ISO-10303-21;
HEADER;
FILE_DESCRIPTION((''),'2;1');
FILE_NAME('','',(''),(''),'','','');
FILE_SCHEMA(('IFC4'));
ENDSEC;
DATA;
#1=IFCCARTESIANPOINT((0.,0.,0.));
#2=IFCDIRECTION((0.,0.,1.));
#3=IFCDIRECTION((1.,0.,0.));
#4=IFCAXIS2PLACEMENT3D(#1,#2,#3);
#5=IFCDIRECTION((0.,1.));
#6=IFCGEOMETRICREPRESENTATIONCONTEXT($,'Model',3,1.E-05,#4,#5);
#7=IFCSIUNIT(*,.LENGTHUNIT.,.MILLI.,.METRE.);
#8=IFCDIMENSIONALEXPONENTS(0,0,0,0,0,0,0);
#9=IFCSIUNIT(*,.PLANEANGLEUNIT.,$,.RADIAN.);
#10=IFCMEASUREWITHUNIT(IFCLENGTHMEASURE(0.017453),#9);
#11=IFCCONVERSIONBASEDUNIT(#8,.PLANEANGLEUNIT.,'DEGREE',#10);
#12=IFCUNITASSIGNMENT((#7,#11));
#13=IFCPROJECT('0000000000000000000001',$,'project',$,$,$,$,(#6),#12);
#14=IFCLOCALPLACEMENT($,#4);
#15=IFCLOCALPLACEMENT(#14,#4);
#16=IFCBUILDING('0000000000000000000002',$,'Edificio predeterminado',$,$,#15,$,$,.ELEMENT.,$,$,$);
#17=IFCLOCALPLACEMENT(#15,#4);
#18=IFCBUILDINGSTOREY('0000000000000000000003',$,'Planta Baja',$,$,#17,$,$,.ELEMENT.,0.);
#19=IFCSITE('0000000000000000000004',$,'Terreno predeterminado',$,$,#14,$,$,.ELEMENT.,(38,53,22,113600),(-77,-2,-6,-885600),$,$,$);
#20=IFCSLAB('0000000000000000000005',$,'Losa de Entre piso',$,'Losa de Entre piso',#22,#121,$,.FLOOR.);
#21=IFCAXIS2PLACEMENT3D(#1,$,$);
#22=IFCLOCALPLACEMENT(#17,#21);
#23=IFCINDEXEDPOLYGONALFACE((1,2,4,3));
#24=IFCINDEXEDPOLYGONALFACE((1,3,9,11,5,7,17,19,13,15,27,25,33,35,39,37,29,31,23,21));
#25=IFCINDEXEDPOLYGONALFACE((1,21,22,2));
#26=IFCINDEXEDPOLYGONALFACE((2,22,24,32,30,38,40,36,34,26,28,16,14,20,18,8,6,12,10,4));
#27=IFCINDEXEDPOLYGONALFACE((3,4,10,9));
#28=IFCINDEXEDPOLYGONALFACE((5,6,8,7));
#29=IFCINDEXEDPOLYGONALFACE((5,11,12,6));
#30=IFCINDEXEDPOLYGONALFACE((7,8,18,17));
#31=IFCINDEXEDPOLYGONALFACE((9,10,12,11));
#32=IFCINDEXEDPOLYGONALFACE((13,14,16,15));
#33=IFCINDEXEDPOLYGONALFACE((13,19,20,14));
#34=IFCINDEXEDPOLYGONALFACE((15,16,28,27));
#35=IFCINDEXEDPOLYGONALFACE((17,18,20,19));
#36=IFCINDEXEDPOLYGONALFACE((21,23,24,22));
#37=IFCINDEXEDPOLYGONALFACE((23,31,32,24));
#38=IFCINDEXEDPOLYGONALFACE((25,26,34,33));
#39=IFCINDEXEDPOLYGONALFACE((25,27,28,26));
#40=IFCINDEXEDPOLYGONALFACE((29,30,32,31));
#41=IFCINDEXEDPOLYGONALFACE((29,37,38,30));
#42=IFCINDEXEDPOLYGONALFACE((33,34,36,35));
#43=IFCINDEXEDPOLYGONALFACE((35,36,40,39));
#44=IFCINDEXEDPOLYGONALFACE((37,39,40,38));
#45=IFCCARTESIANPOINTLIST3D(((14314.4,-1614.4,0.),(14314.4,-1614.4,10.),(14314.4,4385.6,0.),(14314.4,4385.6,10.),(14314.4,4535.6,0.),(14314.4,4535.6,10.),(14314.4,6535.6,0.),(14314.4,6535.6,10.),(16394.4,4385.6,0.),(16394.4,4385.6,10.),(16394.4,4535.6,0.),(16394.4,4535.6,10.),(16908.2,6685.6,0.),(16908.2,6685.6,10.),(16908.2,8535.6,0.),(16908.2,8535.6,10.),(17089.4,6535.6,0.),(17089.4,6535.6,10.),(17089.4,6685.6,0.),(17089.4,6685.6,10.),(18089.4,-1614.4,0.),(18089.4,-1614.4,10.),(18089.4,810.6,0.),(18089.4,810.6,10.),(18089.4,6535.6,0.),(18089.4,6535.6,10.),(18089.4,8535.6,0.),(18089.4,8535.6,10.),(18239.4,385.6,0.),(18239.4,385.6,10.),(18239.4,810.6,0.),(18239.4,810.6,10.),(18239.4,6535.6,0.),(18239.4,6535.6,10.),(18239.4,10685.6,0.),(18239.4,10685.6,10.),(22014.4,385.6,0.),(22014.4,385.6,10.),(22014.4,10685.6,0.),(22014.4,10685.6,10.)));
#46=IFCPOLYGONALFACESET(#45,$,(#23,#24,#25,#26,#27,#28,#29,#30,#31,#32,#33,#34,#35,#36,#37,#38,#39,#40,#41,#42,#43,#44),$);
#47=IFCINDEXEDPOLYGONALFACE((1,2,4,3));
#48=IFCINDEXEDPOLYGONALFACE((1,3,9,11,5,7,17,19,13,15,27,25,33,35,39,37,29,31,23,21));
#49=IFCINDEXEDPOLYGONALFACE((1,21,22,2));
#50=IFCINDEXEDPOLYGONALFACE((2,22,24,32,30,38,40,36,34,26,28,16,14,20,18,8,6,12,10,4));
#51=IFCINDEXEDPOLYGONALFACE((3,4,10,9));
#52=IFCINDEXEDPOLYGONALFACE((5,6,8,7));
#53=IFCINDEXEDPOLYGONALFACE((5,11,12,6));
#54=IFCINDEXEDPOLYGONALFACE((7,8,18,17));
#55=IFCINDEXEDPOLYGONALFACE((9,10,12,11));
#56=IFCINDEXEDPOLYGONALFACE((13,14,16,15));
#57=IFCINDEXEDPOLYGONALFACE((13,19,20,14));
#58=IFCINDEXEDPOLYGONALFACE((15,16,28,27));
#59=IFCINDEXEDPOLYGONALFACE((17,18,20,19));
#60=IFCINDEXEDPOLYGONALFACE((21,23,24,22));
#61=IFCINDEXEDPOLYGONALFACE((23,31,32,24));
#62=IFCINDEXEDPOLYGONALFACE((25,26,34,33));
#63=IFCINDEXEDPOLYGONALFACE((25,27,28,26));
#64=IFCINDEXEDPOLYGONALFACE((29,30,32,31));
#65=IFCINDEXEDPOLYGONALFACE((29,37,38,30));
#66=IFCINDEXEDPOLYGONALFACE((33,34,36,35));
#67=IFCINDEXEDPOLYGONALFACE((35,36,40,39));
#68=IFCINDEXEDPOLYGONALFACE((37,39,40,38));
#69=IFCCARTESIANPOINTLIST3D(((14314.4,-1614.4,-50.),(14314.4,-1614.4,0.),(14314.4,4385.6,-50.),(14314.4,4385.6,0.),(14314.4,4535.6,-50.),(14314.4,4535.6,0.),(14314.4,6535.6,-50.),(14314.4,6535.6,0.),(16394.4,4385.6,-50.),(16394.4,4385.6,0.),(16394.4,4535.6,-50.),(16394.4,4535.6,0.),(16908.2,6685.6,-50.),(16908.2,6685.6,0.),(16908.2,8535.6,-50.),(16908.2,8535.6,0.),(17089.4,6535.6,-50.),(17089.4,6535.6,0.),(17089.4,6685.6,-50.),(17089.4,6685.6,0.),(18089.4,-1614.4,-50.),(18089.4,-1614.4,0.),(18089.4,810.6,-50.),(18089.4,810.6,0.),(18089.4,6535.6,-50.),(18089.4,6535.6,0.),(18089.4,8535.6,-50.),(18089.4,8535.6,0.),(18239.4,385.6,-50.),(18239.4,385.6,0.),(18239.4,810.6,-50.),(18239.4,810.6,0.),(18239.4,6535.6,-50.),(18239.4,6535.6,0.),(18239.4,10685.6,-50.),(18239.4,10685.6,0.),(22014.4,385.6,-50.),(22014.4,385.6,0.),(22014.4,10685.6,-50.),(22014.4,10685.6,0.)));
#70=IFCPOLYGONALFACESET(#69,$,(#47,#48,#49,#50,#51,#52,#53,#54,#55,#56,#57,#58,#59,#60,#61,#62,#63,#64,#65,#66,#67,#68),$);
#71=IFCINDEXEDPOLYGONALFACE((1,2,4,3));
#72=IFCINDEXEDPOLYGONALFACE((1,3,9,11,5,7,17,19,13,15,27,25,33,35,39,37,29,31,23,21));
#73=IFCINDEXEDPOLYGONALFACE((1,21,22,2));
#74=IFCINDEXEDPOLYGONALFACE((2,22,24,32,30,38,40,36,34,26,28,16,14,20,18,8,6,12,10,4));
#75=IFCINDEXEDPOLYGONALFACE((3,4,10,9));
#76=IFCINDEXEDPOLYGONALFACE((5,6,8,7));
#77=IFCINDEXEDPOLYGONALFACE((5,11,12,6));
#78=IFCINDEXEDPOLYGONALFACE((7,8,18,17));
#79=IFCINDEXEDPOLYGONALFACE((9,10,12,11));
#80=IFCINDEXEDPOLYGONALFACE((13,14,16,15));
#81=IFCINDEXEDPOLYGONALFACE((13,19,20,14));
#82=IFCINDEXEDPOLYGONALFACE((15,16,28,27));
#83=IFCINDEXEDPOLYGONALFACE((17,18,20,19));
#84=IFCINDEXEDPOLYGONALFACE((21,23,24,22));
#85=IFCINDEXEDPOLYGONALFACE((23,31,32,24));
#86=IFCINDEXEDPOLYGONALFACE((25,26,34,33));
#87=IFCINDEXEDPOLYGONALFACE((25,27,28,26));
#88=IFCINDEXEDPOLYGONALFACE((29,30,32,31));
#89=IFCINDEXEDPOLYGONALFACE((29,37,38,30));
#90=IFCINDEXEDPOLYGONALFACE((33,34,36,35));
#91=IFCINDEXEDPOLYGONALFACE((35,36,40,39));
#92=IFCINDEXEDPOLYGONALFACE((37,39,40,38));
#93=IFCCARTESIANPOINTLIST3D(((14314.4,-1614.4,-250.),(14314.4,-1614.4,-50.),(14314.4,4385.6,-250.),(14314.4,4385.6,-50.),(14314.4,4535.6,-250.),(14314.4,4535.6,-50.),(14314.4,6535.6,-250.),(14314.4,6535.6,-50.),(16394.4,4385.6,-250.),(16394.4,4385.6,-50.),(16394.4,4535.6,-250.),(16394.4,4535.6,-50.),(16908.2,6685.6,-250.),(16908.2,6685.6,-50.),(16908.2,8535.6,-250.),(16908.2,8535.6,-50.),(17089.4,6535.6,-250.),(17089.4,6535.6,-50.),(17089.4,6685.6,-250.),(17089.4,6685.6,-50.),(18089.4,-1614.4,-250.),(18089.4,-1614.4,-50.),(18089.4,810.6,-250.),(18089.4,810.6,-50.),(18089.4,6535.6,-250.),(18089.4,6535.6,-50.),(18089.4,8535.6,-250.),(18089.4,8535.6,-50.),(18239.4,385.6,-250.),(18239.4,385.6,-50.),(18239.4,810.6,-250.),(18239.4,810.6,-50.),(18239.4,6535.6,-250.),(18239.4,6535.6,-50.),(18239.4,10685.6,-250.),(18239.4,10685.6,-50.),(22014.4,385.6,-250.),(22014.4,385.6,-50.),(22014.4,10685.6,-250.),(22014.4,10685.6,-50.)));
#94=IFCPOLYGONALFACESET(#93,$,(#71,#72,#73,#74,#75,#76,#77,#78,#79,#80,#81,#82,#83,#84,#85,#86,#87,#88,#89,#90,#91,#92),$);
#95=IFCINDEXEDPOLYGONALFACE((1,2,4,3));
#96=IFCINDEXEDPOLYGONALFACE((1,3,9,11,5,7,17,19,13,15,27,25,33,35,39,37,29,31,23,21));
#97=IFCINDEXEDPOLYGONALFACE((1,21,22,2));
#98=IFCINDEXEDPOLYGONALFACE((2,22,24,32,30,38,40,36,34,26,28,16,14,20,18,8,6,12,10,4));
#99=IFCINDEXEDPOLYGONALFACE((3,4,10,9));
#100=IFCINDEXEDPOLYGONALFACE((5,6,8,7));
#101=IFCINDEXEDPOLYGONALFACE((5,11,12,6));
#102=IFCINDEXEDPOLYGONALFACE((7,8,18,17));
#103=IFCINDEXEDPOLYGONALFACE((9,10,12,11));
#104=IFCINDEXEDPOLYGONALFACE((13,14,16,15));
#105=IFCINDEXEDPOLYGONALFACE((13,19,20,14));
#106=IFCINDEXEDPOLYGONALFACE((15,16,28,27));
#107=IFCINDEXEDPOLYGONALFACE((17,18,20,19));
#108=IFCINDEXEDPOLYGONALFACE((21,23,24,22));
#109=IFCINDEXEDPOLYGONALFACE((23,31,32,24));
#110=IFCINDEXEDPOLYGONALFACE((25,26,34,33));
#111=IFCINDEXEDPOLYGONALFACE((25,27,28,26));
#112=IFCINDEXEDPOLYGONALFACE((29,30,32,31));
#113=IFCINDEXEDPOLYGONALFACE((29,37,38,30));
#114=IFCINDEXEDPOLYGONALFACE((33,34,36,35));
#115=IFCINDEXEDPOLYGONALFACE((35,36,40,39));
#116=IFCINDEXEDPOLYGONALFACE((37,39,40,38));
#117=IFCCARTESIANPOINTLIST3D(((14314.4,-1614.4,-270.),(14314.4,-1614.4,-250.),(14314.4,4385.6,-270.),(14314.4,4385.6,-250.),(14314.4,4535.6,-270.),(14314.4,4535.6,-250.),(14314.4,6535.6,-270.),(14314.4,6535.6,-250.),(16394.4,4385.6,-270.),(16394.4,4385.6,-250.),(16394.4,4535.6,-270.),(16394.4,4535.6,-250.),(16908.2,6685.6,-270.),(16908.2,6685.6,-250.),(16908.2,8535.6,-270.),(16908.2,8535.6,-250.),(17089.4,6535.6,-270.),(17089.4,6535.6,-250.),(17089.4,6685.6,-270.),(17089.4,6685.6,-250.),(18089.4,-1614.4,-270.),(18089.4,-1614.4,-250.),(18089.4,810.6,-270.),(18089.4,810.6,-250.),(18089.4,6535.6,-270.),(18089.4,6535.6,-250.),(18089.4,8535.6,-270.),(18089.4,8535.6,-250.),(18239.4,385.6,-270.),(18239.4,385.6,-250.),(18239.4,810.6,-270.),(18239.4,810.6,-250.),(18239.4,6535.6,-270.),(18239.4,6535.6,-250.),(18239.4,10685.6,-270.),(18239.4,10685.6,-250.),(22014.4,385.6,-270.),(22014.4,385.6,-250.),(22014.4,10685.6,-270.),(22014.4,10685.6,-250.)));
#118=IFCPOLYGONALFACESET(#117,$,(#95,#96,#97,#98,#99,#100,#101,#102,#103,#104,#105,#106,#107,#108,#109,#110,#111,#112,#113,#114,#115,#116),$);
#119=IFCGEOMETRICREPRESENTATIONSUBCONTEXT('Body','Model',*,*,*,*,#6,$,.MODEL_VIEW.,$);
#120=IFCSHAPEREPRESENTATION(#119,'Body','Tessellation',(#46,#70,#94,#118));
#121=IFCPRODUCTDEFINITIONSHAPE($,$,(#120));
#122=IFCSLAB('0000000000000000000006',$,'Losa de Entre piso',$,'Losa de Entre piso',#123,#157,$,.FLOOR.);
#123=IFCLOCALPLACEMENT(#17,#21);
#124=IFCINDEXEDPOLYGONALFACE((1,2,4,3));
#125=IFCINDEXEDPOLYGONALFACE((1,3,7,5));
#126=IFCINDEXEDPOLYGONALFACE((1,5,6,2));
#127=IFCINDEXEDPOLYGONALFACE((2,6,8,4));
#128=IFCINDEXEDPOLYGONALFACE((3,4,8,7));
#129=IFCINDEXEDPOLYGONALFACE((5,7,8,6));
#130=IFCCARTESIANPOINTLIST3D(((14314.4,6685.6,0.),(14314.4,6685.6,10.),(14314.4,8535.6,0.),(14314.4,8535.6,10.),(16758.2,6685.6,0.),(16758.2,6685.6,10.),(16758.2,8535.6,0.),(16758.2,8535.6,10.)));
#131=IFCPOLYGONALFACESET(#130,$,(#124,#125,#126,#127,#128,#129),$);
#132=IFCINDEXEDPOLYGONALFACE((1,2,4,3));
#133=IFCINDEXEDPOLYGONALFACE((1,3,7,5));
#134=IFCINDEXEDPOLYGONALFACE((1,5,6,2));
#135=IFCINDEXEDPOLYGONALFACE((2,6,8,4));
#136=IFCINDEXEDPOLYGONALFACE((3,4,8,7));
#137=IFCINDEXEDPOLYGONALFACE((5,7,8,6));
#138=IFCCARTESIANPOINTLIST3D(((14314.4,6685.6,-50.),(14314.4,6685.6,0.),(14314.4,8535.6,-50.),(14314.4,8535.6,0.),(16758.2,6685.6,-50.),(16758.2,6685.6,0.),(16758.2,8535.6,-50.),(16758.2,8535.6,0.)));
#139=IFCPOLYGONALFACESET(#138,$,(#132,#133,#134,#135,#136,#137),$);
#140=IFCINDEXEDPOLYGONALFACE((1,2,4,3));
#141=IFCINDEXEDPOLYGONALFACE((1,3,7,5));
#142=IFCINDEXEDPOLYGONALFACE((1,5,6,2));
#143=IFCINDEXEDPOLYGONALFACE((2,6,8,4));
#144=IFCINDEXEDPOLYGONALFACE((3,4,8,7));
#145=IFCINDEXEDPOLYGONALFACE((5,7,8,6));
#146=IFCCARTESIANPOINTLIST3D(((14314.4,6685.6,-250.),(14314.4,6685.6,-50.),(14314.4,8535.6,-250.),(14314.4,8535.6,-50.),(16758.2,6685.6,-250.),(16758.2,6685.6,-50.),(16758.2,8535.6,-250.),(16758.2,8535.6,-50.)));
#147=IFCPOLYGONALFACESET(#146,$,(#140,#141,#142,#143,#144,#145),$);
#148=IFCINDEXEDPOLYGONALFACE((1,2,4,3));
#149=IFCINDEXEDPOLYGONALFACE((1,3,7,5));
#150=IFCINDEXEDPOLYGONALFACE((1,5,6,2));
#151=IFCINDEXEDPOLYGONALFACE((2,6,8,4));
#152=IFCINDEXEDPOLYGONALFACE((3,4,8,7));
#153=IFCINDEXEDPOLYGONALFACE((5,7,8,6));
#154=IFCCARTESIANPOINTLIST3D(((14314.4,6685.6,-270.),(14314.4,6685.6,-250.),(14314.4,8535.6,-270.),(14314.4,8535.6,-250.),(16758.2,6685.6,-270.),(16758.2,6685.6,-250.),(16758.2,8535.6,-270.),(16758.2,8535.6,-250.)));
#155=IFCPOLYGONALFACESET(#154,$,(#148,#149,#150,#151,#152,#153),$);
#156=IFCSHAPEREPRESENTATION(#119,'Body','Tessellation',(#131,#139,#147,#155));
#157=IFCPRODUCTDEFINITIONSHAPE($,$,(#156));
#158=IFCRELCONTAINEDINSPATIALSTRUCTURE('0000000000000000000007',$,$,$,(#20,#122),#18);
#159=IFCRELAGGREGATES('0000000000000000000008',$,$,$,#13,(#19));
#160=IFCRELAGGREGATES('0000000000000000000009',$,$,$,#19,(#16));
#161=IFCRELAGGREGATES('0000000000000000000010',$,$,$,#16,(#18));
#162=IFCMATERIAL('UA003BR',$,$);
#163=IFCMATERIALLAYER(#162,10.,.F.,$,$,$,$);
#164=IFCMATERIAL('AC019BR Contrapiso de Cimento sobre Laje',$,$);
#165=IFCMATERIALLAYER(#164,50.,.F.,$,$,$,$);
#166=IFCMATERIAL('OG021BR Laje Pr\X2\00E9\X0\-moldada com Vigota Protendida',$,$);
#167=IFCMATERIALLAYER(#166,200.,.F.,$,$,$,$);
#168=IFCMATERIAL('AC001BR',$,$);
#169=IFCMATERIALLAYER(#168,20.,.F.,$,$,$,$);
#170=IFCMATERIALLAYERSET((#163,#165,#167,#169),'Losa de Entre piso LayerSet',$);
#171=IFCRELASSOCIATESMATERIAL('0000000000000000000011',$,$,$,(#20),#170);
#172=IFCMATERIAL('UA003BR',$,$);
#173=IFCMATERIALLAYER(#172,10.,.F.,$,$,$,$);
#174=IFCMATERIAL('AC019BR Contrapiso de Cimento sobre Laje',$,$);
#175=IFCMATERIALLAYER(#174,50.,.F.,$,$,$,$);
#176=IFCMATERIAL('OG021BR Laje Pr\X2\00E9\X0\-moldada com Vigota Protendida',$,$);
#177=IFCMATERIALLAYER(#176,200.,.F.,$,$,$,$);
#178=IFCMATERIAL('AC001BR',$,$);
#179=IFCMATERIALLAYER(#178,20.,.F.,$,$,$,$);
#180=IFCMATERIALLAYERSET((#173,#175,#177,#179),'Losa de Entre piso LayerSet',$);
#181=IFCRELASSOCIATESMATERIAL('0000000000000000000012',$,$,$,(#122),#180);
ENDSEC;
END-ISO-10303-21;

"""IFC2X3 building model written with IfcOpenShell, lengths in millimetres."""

from ifc_helpers import new_model, entity, si_unit, converted_unit, direction, frame, origin_with_axes, place, context, subcontext, project, spatial, polyline, outline, extrude, material, layer, layer_set, layer_usage, element, save


model = new_model("IFC2X3")

# Units and contexts
model_context = context("Model", 3, precision=1e-05, world=origin_with_axes(), true_north=direction((0.0, 1.0)))
body_context = subcontext(model_context, "Body", "Model", "MODEL_VIEW")
ifc_project = project(units=[si_unit("LENGTHUNIT", "METRE", prefix="MILLI"), converted_unit("PLANEANGLEUNIT", "DEGREE", entity("IfcLengthMeasure", 0.017453), si_unit("PLANEANGLEUNIT", "RADIAN"), dimensions=[0, 0, 0, 0, 0, 0, 0])], contexts=[model_context])

# Site, building, storey
site_placement = place(None, origin_with_axes())
site = spatial("IfcSite", under=ifc_project, at=site_placement, Name="Terreno predeterminado", CompositionType="ELEMENT", RefLatitude=(38, 53, 22, 113600), RefLongitude=(-77, -2, -6, -885600))
building_placement = place(site_placement, origin_with_axes())
building = spatial("IfcBuilding", under=site, at=building_placement, Name="Edificio predeterminado", CompositionType="ELEMENT")
storey_placement = place(building_placement, origin_with_axes())
storey = spatial("IfcBuildingStorey", under=building, at=storey_placement, Name="Planta Baja", CompositionType="ELEMENT", Elevation=0.0)

# Slabs
ifc_material_1 = material(Name="UA003BR")
ifc_layer_1 = layer(ifc_material_1, 10.0, ventilated=False)
ifc_material_2 = material(Name="AC019BR Contrapiso de Cimento sobre Laje")
ifc_layer_2 = layer(ifc_material_2, 50.0, ventilated=False)
ifc_material_3 = material(Name="OG021BR Laje Pré-moldada com Vigota Protendida")
ifc_layer_3 = layer(ifc_material_3, 200.0, ventilated=False)
ifc_material_4 = material(Name="AC001BR")
ifc_layer_4 = layer(ifc_material_4, 20.0, ventilated=False)
ifc_layer_set_1 = layer_set([ifc_layer_1, ifc_layer_2, ifc_layer_3, ifc_layer_4], Name="Losa de Entre piso LayerSet")
ifc_layer_usage_1 = layer_usage(ifc_layer_set_1, "AXIS3", "POSITIVE", 0.0)
slab_1_placement = place(storey_placement, origin_with_axes())
element("IfcSlab", 1, at=slab_1_placement, inside=storey, material=ifc_layer_usage_1, Name="Losa de Entre piso", ObjectType="Losa de Entre piso", PredefinedType="FLOOR", context=body_context, shape_type="SweptSolid", body=[
    extrude(outline(polyline([(0.0, -6000.0), (3775.0, -6000.0), (3775.0, -3575.0), (3925.0, -3575.0), (3925.0, -4000.0), (7700.0, -4000.0), (7700.0, 6300.0), (3925.0, 6300.0), (3925.0, 2150.0), (3775.0, 2150.0), (3775.0, 4150.0), (2593.9, 4150.0), (2593.9, 2300.0), (2775.0, 2300.0), (2775.0, 2150.0), (0.0, 2150.0), (0.0, 150.0), (2080.0, 150.0), (2080.0, 0.0), (0.0, 0.0), (0.0, -6000.0)])), frame((14314.4, 4385.6, 0.0), z_axis=(0.0, 0.0, 1.0), x_axis=(1.0, 0.0, 0.0)), (0.0, 0.0, 1.0), 10.0),
    extrude(outline(polyline([(0.0, -6000.0), (3775.0, -6000.0), (3775.0, -3575.0), (3925.0, -3575.0), (3925.0, -4000.0), (7700.0, -4000.0), (7700.0, 6300.0), (3925.0, 6300.0), (3925.0, 2150.0), (3775.0, 2150.0), (3775.0, 4150.0), (2593.9, 4150.0), (2593.9, 2300.0), (2775.0, 2300.0), (2775.0, 2150.0), (0.0, 2150.0), (0.0, 150.0), (2080.0, 150.0), (2080.0, 0.0), (0.0, 0.0), (0.0, -6000.0)])), frame((14314.4, 4385.6, -50.0), z_axis=(0.0, 0.0, 1.0), x_axis=(1.0, 0.0, 0.0)), (0.0, 0.0, 1.0), 50.0),
    extrude(outline(polyline([(0.0, -6000.0), (3775.0, -6000.0), (3775.0, -3575.0), (3925.0, -3575.0), (3925.0, -4000.0), (7700.0, -4000.0), (7700.0, 6300.0), (3925.0, 6300.0), (3925.0, 2150.0), (3775.0, 2150.0), (3775.0, 4150.0), (2593.9, 4150.0), (2593.9, 2300.0), (2775.0, 2300.0), (2775.0, 2150.0), (0.0, 2150.0), (0.0, 150.0), (2080.0, 150.0), (2080.0, 0.0), (0.0, 0.0), (0.0, -6000.0)])), frame((14314.4, 4385.6, -250.0), z_axis=(0.0, 0.0, 1.0), x_axis=(1.0, 0.0, 0.0)), (0.0, 0.0, 1.0), 200.0),
    extrude(outline(polyline([(0.0, -6000.0), (3775.0, -6000.0), (3775.0, -3575.0), (3925.0, -3575.0), (3925.0, -4000.0), (7700.0, -4000.0), (7700.0, 6300.0), (3925.0, 6300.0), (3925.0, 2150.0), (3775.0, 2150.0), (3775.0, 4150.0), (2593.9, 4150.0), (2593.9, 2300.0), (2775.0, 2300.0), (2775.0, 2150.0), (0.0, 2150.0), (0.0, 150.0), (2080.0, 150.0), (2080.0, 0.0), (0.0, 0.0), (0.0, -6000.0)])), frame((14314.4, 4385.6, -270.0), z_axis=(0.0, 0.0, 1.0), x_axis=(1.0, 0.0, 0.0)), (0.0, 0.0, 1.0), 20.0),
])
ifc_material_5 = material(Name="UA003BR")
ifc_layer_5 = layer(ifc_material_5, 10.0, ventilated=False)
ifc_material_6 = material(Name="AC019BR Contrapiso de Cimento sobre Laje")
ifc_layer_6 = layer(ifc_material_6, 50.0, ventilated=False)
ifc_material_7 = material(Name="OG021BR Laje Pré-moldada com Vigota Protendida")
ifc_layer_7 = layer(ifc_material_7, 200.0, ventilated=False)
ifc_material_8 = material(Name="AC001BR")
ifc_layer_8 = layer(ifc_material_8, 20.0, ventilated=False)
ifc_layer_set_2 = layer_set([ifc_layer_5, ifc_layer_6, ifc_layer_7, ifc_layer_8], Name="Losa de Entre piso LayerSet")
ifc_layer_usage_2 = layer_usage(ifc_layer_set_2, "AXIS3", "NEGATIVE", 0.0)
slab_2_placement = place(storey_placement, origin_with_axes())
element("IfcSlab", 2, at=slab_2_placement, inside=storey, material=ifc_layer_usage_2, Name="Losa de Entre piso", ObjectType="Losa de Entre piso", PredefinedType="FLOOR", context=body_context, shape_type="SweptSolid", body=[
    extrude(outline(polyline([(0.0, 2443.9), (1850.0, 2443.9), (1850.0, 0.0), (0.0, 0.0), (0.0, 2443.9)])), frame((14314.4, 6685.6, 0.0), z_axis=(0.0, 0.0, -1.0), x_axis=(0.0, 1.0, 0.0)), (0.0, 0.0, -1.0), 10.0),
    extrude(outline(polyline([(0.0, 2443.9), (1850.0, 2443.9), (1850.0, 0.0), (0.0, 0.0), (0.0, 2443.9)])), frame((14314.4, 6685.6, -50.0), z_axis=(0.0, 0.0, -1.0), x_axis=(0.0, 1.0, 0.0)), (0.0, 0.0, -1.0), 50.0),
    extrude(outline(polyline([(0.0, 2443.9), (1850.0, 2443.9), (1850.0, 0.0), (0.0, 0.0), (0.0, 2443.9)])), frame((14314.4, 6685.6, -250.0), z_axis=(0.0, 0.0, -1.0), x_axis=(0.0, 1.0, 0.0)), (0.0, 0.0, -1.0), 200.0),
    extrude(outline(polyline([(0.0, 2443.9), (1850.0, 2443.9), (1850.0, 0.0), (0.0, 0.0), (0.0, 2443.9)])), frame((14314.4, 6685.6, -270.0), z_axis=(0.0, 0.0, -1.0), x_axis=(0.0, 1.0, 0.0)), (0.0, 0.0, -1.0), 20.0),
])

save(model, "model.ifc")
